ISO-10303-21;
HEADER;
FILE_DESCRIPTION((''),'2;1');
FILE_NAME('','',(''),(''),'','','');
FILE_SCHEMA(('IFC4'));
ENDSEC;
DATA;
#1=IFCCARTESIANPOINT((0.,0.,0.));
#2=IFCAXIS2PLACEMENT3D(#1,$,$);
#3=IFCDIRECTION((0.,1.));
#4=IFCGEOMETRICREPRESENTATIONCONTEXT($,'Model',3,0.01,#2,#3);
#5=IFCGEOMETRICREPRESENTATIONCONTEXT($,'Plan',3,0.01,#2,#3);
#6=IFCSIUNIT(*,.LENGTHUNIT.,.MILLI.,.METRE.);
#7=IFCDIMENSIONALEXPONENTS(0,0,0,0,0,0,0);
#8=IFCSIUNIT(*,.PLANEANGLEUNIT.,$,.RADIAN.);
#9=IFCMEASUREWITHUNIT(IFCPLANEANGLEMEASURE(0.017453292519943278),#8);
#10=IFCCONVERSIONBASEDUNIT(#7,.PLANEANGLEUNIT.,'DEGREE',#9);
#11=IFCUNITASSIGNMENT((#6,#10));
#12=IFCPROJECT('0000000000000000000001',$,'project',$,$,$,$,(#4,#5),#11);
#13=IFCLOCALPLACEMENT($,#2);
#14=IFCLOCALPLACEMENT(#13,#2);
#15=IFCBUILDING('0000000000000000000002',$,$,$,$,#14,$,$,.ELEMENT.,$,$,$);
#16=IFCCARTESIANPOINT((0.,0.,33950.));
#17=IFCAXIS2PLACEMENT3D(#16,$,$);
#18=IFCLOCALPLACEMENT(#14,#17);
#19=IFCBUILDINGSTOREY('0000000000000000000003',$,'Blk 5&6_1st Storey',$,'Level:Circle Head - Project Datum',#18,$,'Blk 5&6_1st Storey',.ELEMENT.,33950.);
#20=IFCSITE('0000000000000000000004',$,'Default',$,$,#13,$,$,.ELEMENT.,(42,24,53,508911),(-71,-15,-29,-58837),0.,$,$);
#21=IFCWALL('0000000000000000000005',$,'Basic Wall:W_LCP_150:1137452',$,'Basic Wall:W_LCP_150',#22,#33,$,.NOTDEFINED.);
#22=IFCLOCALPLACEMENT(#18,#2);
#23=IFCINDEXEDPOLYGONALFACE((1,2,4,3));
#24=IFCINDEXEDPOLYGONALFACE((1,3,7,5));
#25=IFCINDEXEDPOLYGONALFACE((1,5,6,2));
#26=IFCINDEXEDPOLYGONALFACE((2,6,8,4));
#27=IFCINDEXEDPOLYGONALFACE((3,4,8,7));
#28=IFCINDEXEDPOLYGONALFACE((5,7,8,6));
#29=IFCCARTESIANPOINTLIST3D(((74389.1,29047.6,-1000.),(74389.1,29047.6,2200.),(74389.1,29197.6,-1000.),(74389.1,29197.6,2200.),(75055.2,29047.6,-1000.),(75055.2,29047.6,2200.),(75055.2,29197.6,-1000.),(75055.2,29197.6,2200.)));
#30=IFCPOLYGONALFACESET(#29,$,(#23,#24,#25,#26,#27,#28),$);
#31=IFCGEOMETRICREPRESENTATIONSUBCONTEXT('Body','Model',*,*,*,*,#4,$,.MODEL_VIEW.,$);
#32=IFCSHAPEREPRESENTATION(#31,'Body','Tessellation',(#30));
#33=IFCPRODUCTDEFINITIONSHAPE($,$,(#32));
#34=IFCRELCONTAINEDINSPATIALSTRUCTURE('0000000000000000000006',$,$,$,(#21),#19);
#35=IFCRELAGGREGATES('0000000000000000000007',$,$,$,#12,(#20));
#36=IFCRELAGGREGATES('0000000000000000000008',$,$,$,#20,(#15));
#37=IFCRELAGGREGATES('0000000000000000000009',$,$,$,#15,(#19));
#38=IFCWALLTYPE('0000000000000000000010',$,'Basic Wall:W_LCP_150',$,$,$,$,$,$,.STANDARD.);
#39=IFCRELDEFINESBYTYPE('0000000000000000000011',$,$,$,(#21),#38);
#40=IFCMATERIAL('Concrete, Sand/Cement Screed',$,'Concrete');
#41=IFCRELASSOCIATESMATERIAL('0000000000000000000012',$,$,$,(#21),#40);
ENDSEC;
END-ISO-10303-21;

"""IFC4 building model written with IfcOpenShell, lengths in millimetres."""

from ifc_helpers import new_model, entity, si_unit, converted_unit, direction, frame, origin, place, context, subcontext, project, spatial, indexed_curve, outline, extrude, material, type_object, element, save


model = new_model("IFC4")

# Units and contexts
model_context = context("Model", 3, precision=0.01, world=origin(), true_north=direction((0.0, 1.0)))
plan_context = context("Plan", 3, precision=0.01, world=origin(), true_north=direction((0.0, 1.0)))
body_context = subcontext(model_context, "Body", "Model", "MODEL_VIEW")
ifc_project = project(units=[si_unit("LENGTHUNIT", "METRE", prefix="MILLI"), converted_unit("PLANEANGLEUNIT", "DEGREE", entity("IfcPlaneAngleMeasure", 0.017453292519943278), si_unit("PLANEANGLEUNIT", "RADIAN"), dimensions=[0, 0, 0, 0, 0, 0, 0])], contexts=[model_context, plan_context])

# Site, building, storey
site_placement = place(None, origin())
site = spatial("IfcSite", under=ifc_project, at=site_placement, Name="Default", CompositionType="ELEMENT", RefLatitude=(42, 24, 53, 508911), RefLongitude=(-71, -15, -29, -58837), RefElevation=0.0)
building_placement = place(site_placement, origin())
building = spatial("IfcBuilding", under=site, at=building_placement, CompositionType="ELEMENT")
storey_placement = place(building_placement, frame((0.0, 0.0, 33950.0)))
storey = spatial("IfcBuildingStorey", under=building, at=storey_placement, Name="Blk 5&6_1st Storey", ObjectType="Level:Circle Head - Project Datum", LongName="Blk 5&6_1st Storey", CompositionType="ELEMENT", Elevation=33950.0)

# Shared definitions
ifc_material_1 = material(Name="Concrete, Sand/Cement Screed", Category="Concrete")

# Wall
wall_type_1 = type_object("IfcWallType", Name="Basic Wall:W_LCP_150", PredefinedType="STANDARD")
wall_1_placement = place(storey_placement, frame((74389.1, 29122.6, -1000.0)))
element("IfcWall", 1, at=wall_1_placement, inside=storey, type_object=wall_type_1, material=ifc_material_1, Name="Basic Wall:W_LCP_150:1137452", ObjectType="Basic Wall:W_LCP_150", PredefinedType="NOTDEFINED", context=body_context, shape_type="SweptSolid", body=[
    extrude(outline(indexed_curve([(666.0, 75.0), (0.0, 75.0), (0.0, -75.0), (666.0, -75.0), (666.0, 75.0)], self_intersect=False)), origin(), (0.0, 0.0, 1.0), 3200.0),
])

save(model, "model.ifc")
